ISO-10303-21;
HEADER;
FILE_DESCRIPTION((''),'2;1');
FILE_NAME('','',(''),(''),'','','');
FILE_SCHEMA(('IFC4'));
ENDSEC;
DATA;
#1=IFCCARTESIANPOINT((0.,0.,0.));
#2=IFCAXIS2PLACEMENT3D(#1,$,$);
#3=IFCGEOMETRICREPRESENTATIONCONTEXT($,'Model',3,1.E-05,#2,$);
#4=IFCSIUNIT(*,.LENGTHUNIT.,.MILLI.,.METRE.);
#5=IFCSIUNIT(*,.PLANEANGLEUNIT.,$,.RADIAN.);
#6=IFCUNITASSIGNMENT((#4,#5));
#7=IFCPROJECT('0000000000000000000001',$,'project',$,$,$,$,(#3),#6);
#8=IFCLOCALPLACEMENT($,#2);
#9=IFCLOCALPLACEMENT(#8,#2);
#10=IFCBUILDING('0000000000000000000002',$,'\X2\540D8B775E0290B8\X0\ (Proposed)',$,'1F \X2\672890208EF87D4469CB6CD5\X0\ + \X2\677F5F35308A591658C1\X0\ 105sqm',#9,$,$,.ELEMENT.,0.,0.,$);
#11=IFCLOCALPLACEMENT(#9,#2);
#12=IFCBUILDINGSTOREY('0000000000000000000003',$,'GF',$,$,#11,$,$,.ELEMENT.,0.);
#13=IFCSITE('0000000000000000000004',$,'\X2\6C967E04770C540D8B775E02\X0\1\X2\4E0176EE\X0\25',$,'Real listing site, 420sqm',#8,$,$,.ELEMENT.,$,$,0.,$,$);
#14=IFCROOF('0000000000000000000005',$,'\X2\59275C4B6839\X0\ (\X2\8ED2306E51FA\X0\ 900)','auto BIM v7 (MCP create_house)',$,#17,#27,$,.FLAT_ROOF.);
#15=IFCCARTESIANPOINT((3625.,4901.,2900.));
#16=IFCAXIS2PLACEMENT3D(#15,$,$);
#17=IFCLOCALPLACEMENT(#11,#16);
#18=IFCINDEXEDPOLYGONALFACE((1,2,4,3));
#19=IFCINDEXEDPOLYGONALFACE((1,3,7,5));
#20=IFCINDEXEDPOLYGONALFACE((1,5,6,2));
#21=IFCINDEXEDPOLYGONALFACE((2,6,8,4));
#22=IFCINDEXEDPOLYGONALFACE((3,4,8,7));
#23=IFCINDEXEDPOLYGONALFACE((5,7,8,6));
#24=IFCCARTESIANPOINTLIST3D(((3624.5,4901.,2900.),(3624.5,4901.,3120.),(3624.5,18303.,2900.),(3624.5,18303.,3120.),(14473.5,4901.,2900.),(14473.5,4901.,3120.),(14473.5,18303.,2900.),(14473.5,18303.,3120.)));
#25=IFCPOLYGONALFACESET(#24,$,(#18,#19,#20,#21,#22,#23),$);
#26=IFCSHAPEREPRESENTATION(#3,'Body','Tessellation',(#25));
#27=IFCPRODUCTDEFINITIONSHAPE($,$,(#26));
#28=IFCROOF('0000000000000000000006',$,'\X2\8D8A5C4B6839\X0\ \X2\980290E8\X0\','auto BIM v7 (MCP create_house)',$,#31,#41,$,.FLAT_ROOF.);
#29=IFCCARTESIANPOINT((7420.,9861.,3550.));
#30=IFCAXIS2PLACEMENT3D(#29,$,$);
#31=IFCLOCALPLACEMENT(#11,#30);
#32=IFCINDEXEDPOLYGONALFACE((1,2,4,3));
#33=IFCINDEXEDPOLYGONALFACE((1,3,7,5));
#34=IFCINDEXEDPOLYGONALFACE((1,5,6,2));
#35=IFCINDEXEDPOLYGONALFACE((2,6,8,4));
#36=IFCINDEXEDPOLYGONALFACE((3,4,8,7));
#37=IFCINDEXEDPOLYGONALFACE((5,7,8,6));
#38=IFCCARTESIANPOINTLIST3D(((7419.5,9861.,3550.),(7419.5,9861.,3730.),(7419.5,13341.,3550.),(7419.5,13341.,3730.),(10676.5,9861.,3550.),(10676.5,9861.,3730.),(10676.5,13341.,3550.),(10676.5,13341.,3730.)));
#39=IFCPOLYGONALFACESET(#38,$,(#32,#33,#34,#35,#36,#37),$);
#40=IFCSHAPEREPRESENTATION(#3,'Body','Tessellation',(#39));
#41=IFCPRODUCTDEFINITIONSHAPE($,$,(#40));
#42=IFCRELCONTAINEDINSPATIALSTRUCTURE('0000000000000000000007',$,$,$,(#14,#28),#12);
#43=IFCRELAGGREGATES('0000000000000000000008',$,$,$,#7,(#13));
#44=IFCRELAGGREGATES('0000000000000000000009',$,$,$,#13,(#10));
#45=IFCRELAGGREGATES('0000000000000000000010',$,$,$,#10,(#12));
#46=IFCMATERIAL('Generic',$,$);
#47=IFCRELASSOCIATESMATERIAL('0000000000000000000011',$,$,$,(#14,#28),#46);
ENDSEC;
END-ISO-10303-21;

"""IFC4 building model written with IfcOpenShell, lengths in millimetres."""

from ifc_helpers import new_model, si_unit, frame, frame_2d, origin, place, context, project, spatial, rectangle, extrude, material, element, save


model = new_model("IFC4")

# Units and contexts
model_context = context("Model", 3, precision=1e-05, world=origin())
ifc_project = project(units=[si_unit("LENGTHUNIT", "METRE", prefix="MILLI"), si_unit("PLANEANGLEUNIT", "RADIAN")], contexts=[model_context])

# Site, building, storey
site_placement = place(None, origin())
site = spatial("IfcSite", under=ifc_project, at=site_placement, Name="沖縄県名護市1丁目25", ObjectType="Real listing site, 420sqm", CompositionType="ELEMENT", RefElevation=0.0)
building_placement = place(site_placement, origin())
building = spatial("IfcBuilding", under=site, at=building_placement, Name="名護市邸 (Proposed)", ObjectType="1F 木造軸組構法 + 板張り外壁 105sqm", CompositionType="ELEMENT", ElevationOfRefHeight=0.0, ElevationOfTerrain=0.0)
storey_placement = place(building_placement, origin())
storey = spatial("IfcBuildingStorey", under=building, at=storey_placement, Name="GF", CompositionType="ELEMENT", Elevation=0.0)

# Shared definitions
ifc_material = material(Name="Generic")

# Roofs
roof_1_placement = place(storey_placement, frame((3625.0, 4901.0, 2900.0)))
element("IfcRoof", 1, at=roof_1_placement, inside=storey, material=ifc_material, Name="大屋根 (軒の出 900)", Description="auto BIM v7 (MCP create_house)", PredefinedType="FLAT_ROOF", context=model_context, shape_type="SweptSolid", body=[
    extrude(rectangle(XDim=10849.0, YDim=13402.0, at=frame_2d((5424.0, 6701.0))), frame((3625.0, 4901.0, 2900.0)), (0.0, 0.0, 1.0), 220.0),
])
roof_2_placement = place(storey_placement, frame((7420.0, 9861.0, 3550.0)))
element("IfcRoof", 2, at=roof_2_placement, inside=storey, material=ifc_material, Name="越屋根 頂部", Description="auto BIM v7 (MCP create_house)", PredefinedType="FLAT_ROOF", context=model_context, shape_type="SweptSolid", body=[
    extrude(rectangle(XDim=3257.0, YDim=3480.0, at=frame_2d((1628.0, 1740.0))), frame((7420.0, 9861.0, 3550.0)), (0.0, 0.0, 1.0), 180.0),
])

save(model, "model.ifc")
